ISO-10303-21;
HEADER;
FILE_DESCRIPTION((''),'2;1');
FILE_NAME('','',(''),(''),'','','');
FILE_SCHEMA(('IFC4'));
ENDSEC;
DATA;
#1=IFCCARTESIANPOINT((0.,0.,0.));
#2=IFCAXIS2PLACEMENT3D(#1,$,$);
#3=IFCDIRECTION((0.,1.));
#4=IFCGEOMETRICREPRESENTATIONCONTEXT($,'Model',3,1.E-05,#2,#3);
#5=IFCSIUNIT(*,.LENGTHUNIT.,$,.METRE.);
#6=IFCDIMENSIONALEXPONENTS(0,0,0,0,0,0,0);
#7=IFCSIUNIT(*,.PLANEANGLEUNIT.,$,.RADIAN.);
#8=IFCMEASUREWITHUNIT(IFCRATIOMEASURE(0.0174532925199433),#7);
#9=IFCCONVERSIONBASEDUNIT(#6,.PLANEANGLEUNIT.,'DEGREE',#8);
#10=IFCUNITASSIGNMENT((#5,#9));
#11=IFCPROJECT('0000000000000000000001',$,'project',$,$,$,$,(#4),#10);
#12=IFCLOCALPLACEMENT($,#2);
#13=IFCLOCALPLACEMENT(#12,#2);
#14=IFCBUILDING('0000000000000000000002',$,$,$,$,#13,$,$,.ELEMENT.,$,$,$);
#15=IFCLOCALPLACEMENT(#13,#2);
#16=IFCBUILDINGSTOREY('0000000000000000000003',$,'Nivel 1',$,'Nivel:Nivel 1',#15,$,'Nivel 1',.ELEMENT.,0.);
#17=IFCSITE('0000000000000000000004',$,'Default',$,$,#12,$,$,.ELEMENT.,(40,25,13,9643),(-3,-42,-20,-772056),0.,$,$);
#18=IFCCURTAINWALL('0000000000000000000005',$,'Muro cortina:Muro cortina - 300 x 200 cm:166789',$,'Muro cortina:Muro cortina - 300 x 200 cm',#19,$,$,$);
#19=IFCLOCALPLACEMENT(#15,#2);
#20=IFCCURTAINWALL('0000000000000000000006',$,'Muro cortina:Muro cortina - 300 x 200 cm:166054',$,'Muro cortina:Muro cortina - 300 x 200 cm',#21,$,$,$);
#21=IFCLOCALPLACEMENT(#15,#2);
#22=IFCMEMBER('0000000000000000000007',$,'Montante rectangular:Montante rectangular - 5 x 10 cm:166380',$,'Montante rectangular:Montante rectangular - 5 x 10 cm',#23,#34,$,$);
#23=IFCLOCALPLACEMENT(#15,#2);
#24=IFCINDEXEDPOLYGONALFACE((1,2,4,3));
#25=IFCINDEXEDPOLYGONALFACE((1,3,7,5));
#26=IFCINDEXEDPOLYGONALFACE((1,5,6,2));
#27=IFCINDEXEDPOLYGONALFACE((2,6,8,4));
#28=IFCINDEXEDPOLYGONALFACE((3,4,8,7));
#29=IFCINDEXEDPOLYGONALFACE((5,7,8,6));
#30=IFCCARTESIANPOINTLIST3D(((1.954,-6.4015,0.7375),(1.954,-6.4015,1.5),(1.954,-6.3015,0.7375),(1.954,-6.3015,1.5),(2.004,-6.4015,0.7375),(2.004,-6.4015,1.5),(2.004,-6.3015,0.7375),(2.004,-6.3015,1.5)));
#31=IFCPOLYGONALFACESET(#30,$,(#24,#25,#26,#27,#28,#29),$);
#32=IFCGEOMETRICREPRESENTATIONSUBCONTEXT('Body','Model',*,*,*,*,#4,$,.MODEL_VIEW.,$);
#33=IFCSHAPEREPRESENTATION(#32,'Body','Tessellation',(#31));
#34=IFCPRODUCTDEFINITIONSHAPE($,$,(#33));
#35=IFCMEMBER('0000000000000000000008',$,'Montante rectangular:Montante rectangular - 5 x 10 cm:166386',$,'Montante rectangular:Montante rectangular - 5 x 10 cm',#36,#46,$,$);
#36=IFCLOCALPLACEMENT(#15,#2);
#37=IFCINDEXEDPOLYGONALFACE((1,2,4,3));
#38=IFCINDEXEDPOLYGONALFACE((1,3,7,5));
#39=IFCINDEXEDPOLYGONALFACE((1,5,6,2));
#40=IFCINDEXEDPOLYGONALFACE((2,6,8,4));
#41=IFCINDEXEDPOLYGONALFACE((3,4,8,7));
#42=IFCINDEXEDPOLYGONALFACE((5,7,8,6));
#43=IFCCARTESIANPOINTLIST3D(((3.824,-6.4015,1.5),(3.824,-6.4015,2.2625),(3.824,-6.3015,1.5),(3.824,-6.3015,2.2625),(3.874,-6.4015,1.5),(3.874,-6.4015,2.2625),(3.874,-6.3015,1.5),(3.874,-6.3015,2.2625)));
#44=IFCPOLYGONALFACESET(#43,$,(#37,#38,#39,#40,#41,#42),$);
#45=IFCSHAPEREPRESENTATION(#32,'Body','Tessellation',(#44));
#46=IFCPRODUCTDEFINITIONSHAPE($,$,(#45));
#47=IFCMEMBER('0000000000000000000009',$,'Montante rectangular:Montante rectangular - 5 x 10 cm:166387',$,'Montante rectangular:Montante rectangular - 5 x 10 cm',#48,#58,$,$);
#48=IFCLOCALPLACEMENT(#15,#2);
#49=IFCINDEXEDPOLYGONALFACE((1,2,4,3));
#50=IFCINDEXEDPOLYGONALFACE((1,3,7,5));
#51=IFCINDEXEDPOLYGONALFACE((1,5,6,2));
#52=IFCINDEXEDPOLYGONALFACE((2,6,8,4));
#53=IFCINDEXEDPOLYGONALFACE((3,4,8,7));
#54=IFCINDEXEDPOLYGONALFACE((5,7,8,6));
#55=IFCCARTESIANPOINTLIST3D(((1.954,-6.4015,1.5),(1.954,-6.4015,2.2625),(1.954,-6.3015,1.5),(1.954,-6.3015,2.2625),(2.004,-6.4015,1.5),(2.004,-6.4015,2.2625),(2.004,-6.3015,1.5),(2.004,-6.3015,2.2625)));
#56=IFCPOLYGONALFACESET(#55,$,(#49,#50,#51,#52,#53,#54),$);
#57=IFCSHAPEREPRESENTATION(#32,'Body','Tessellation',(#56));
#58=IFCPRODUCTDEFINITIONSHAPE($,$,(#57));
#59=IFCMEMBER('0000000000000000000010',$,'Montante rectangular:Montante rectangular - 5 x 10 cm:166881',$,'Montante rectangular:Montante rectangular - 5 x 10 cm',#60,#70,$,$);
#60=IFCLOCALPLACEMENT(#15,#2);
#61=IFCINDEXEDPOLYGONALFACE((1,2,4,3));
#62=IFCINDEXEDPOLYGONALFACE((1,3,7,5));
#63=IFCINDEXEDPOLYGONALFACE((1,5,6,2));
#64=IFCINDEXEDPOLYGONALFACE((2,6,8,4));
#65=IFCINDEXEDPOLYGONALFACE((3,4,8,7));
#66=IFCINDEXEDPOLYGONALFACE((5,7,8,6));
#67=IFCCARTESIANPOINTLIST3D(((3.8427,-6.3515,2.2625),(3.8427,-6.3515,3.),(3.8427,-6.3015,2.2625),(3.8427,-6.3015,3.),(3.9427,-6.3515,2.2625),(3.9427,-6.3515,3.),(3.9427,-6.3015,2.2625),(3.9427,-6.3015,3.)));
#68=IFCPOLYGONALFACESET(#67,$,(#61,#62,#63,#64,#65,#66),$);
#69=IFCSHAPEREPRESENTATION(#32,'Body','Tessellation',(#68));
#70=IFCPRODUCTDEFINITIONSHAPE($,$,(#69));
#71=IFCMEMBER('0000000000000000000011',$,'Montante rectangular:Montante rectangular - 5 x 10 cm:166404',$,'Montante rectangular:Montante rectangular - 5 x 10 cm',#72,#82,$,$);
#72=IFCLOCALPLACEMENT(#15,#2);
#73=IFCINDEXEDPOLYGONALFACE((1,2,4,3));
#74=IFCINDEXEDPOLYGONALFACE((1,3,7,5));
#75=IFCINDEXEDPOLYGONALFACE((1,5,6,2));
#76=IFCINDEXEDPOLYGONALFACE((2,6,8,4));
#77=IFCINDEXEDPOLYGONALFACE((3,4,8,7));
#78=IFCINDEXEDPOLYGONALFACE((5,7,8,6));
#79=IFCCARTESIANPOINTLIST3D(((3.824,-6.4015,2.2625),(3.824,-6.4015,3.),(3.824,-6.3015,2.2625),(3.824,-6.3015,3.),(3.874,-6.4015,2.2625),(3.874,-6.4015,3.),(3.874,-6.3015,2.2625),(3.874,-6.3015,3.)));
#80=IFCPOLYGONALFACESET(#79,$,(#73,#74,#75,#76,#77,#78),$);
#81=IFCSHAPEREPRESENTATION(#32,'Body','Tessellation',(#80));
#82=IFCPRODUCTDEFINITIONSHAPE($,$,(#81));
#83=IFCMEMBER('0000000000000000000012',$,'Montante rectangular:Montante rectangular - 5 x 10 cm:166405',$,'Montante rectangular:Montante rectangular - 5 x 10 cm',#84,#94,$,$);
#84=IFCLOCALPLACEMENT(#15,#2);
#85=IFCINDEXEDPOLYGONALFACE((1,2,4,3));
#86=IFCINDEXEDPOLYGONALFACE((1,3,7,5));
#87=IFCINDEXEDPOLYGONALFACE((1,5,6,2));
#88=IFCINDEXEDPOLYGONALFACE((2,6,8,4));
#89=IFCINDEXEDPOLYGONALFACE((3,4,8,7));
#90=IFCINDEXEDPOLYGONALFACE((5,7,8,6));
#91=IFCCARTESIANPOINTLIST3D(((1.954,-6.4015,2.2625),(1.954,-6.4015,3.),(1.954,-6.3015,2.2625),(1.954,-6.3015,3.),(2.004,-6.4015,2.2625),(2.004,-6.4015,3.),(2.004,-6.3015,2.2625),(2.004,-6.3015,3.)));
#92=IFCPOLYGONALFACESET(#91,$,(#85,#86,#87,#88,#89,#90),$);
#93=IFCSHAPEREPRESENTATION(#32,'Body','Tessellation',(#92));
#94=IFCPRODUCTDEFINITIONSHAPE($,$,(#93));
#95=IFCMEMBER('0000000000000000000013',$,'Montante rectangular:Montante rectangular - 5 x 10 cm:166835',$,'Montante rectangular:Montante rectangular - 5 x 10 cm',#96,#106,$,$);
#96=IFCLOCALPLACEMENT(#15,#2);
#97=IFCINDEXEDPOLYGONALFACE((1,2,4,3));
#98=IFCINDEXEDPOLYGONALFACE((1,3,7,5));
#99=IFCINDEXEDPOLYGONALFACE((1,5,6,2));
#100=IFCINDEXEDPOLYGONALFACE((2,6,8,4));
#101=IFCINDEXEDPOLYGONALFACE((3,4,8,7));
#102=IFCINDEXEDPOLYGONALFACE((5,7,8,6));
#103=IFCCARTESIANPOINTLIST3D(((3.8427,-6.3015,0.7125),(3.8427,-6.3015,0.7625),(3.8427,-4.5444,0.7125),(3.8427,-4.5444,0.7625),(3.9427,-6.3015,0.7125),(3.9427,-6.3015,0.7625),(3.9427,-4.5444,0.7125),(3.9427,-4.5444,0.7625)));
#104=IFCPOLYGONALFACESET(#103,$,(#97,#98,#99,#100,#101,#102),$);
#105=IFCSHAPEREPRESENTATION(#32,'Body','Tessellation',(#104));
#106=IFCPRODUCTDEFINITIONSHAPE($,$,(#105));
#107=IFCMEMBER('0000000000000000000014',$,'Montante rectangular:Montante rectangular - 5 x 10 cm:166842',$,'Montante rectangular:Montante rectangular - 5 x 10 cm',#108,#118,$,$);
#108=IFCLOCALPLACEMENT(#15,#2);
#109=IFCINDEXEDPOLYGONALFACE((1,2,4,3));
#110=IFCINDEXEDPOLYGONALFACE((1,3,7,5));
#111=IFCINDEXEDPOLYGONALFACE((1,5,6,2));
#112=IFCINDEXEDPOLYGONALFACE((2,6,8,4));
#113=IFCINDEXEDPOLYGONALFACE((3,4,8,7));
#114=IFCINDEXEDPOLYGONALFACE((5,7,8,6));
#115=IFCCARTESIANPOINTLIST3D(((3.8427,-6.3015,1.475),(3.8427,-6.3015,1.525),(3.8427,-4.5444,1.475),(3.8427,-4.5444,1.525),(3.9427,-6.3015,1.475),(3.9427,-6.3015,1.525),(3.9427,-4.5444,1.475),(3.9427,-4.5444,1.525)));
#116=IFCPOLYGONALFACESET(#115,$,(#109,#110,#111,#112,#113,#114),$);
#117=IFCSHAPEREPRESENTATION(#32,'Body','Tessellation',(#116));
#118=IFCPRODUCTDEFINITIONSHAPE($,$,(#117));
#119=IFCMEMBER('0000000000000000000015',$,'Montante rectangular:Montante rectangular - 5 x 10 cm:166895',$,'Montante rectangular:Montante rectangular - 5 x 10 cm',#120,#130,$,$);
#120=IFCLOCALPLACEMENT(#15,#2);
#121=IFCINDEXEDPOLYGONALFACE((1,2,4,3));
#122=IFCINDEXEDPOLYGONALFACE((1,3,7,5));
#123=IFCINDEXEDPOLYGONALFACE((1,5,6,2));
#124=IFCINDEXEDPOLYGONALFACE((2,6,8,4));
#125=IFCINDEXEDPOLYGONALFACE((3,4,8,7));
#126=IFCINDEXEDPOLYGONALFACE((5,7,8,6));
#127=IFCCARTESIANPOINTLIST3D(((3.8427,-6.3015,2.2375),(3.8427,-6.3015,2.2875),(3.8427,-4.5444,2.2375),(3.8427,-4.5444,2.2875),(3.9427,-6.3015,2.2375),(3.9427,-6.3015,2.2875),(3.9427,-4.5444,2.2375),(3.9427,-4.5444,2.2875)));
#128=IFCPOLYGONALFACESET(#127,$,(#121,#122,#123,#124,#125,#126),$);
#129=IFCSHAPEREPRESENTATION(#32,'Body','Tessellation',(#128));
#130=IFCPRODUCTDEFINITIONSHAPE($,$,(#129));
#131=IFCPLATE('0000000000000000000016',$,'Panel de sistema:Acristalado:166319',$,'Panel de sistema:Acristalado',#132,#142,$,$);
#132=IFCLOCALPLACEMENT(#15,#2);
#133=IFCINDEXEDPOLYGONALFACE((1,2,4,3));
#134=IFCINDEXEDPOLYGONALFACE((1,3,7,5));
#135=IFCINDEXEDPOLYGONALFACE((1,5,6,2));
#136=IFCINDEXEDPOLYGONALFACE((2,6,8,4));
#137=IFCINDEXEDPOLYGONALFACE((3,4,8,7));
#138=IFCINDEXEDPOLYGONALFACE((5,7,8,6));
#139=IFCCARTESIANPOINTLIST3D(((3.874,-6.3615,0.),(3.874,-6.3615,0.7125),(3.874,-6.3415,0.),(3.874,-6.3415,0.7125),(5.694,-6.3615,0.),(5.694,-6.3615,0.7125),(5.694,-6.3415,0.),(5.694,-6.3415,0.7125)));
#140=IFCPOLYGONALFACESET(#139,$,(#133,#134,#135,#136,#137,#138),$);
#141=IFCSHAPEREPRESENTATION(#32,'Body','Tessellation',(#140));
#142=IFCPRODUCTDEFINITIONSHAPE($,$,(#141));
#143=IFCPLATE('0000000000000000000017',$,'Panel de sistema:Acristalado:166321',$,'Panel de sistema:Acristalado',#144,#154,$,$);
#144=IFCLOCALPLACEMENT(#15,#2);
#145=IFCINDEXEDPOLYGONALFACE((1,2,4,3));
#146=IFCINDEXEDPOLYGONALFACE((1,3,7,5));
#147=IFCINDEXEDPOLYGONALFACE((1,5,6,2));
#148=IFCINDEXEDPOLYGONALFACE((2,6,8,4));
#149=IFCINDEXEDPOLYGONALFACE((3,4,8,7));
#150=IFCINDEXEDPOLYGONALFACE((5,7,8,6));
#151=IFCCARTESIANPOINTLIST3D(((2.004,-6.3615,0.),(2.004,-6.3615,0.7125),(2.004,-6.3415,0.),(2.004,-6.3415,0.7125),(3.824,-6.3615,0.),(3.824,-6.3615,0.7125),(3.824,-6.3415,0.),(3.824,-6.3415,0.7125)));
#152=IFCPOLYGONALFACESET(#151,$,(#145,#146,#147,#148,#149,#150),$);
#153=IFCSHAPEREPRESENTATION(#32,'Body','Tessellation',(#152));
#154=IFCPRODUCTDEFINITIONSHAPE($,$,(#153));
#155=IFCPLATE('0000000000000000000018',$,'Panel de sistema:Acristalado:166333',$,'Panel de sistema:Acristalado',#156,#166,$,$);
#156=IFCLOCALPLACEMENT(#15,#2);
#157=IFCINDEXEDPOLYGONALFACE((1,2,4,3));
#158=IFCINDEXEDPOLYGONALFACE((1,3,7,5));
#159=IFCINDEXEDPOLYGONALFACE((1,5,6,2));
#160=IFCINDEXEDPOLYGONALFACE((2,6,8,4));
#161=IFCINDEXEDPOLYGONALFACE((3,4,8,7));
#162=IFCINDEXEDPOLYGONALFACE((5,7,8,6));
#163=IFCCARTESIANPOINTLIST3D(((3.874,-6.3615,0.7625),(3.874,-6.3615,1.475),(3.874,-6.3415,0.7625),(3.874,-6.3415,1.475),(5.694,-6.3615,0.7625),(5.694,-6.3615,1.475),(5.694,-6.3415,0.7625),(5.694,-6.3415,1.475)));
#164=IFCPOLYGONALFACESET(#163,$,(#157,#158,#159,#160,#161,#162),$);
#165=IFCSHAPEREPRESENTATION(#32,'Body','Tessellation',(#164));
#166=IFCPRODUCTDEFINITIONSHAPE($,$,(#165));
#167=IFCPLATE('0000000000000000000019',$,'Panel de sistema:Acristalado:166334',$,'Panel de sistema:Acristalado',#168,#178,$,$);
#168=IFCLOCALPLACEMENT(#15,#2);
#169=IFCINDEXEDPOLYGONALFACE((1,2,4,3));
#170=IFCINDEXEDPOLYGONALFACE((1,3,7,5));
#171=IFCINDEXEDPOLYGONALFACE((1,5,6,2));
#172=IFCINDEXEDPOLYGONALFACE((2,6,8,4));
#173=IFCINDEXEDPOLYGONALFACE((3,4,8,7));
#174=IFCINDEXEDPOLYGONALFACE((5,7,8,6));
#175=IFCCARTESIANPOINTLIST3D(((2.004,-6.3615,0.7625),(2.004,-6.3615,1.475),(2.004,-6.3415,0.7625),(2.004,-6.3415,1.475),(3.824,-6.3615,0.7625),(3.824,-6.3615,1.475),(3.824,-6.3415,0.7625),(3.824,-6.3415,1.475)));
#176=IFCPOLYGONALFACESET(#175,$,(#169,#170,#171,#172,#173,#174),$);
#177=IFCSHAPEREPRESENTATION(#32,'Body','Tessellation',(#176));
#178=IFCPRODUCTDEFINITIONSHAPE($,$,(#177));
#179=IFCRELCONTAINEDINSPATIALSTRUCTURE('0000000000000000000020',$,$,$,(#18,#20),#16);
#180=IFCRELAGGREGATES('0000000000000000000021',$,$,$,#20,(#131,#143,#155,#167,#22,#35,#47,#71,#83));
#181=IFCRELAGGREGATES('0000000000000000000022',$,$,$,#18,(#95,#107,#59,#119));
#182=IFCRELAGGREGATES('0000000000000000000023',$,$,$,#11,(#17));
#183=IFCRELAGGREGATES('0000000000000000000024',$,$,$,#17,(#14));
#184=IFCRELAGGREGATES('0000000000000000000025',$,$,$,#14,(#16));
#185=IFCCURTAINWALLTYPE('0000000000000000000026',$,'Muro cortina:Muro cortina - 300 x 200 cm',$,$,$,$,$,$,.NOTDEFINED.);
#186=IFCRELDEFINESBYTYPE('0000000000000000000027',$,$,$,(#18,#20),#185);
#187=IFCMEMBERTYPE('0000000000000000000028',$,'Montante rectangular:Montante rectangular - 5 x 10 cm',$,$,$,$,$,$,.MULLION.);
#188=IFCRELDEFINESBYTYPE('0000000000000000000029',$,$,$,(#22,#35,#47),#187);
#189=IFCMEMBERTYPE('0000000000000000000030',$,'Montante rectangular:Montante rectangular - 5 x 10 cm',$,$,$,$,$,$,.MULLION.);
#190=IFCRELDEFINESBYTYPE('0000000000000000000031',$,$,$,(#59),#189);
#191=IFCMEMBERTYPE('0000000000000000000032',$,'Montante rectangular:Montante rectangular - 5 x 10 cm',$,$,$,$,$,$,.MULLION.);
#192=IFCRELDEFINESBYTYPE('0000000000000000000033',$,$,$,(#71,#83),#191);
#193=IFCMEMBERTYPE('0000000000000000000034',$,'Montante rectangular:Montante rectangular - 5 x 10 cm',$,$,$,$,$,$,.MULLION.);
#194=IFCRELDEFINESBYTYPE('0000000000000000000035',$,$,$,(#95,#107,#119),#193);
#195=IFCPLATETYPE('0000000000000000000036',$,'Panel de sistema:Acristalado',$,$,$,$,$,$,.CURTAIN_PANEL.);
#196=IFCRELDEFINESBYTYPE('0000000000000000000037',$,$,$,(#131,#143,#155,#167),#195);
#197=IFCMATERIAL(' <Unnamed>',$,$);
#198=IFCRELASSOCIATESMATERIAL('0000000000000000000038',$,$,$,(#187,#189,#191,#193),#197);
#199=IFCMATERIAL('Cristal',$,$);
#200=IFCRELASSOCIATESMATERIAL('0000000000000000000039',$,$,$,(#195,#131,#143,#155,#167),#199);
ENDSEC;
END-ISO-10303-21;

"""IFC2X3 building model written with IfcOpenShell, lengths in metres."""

from ifc_helpers import new_model, entity, si_unit, converted_unit, direction, frame, origin, origin_2d_with_axis, place, context, subcontext, project, spatial, rectangle, extrude, source, transform, mapped, material, type_object, type_shapes, element, aggregate, save


model = new_model("IFC2X3")

# Units and contexts
model_context = context("Model", 3, precision=1e-05, world=origin(), true_north=direction((0.0, 1.0)))
body_context = subcontext(model_context, "Body", "Model", "MODEL_VIEW")
ifc_project = project(units=[si_unit("LENGTHUNIT", "METRE"), converted_unit("PLANEANGLEUNIT", "DEGREE", entity("IfcRatioMeasure", 0.0174532925199433), si_unit("PLANEANGLEUNIT", "RADIAN"), dimensions=[0, 0, 0, 0, 0, 0, 0])], contexts=[model_context])

# Site, building, storey
site_placement = place(None, origin())
site = spatial("IfcSite", under=ifc_project, at=site_placement, Name="Default", CompositionType="ELEMENT", RefLatitude=(40, 25, 13, 9643), RefLongitude=(-3, -42, -20, -772056), RefElevation=0.0)
building_placement = place(site_placement, origin())
building = spatial("IfcBuilding", under=site, at=building_placement, CompositionType="ELEMENT")
storey_placement = place(building_placement, origin())
storey = spatial("IfcBuildingStorey", under=building, at=storey_placement, Name="Nivel 1", ObjectType="Nivel:Nivel 1", LongName="Nivel 1", CompositionType="ELEMENT", Elevation=0.0)

# Curtain walls, members
curtain_wall_type = type_object("IfcCurtainWallType", Name="Muro cortina:Muro cortina - 300 x 200 cm", PredefinedType="NOTDEFINED")
curtain_wall_1_placement = place(storey_placement, origin())
curtain_wall_1 = element("IfcCurtainWall", 1, at=curtain_wall_1_placement, inside=storey, type_object=curtain_wall_type, Name="Muro cortina:Muro cortina - 300 x 200 cm:166789", ObjectType="Muro cortina:Muro cortina - 300 x 200 cm")
ifc_material_1 = material(Name=" <Unnamed>")
curtain_wall_2_placement = place(storey_placement, origin())
curtain_wall_2 = element("IfcCurtainWall", 2, at=curtain_wall_2_placement, inside=storey, type_object=curtain_wall_type, Name="Muro cortina:Muro cortina - 300 x 200 cm:166054", ObjectType="Muro cortina:Muro cortina - 300 x 200 cm")
member_type_1 = type_object("IfcMemberType", Name="Montante rectangular:Montante rectangular - 5 x 10 cm", PredefinedType="MULLION", material=ifc_material_1)
shared_shape_1 = source(origin(), body_context, "Body", "SweptSolid", [
    extrude(rectangle(XDim=0.1, YDim=0.05, at=origin_2d_with_axis()), frame((0.0, 0.0, -0.7625), z_axis=(0.0, 0.0, 1.0), x_axis=(0.0, -1.0, 0.0)), (0.0, 0.0, 1.0), 0.7625),
])
type_shapes(member_type_1, [shared_shape_1])
member_1_placement = place(storey_placement, frame((1.979, -6.3515, 0.7375), z_axis=(0.0, 0.0, -1.0), x_axis=(-1.0, 0.0, 0.0)))
member_1 = element("IfcMember", 3, at=member_1_placement, type_object=member_type_1, Name="Montante rectangular:Montante rectangular - 5 x 10 cm:166380", ObjectType="Montante rectangular:Montante rectangular - 5 x 10 cm", context=body_context, shape_type="MappedRepresentation", body=[
    mapped(shared_shape_1, transform((0.0, 0.0, 0.0), scale=1.0)),
])
member_2_placement = place(storey_placement, frame((3.849, -6.3515, 1.5), z_axis=(0.0, 0.0, -1.0), x_axis=(-1.0, 0.0, 0.0)))
member_2 = element("IfcMember", 4, at=member_2_placement, type_object=member_type_1, Name="Montante rectangular:Montante rectangular - 5 x 10 cm:166386", ObjectType="Montante rectangular:Montante rectangular - 5 x 10 cm", context=body_context, shape_type="MappedRepresentation", body=[
    mapped(shared_shape_1, transform((0.0, 0.0, 0.0), scale=1.0)),
])
member_3_placement = place(storey_placement, frame((1.979, -6.3515, 1.5), z_axis=(0.0, 0.0, -1.0), x_axis=(-1.0, 0.0, 0.0)))
member_3 = element("IfcMember", 5, at=member_3_placement, type_object=member_type_1, Name="Montante rectangular:Montante rectangular - 5 x 10 cm:166387", ObjectType="Montante rectangular:Montante rectangular - 5 x 10 cm", context=body_context, shape_type="MappedRepresentation", body=[
    mapped(shared_shape_1, transform((0.0, 0.0, 0.0), scale=1.0)),
])

# Members
member_type_2 = type_object("IfcMemberType", Name="Montante rectangular:Montante rectangular - 5 x 10 cm", PredefinedType="MULLION", material=ifc_material_1)
shared_shape_2 = source(origin(), body_context, "Body", "SweptSolid", [
    extrude(rectangle(XDim=0.1, YDim=0.05, at=origin_2d_with_axis()), frame((-0.025, 0.0, -0.7375), z_axis=(0.0, 0.0, 1.0), x_axis=(0.0, -1.0, 0.0)), (0.0, 0.0, 1.0), 0.7375),
])
type_shapes(member_type_2, [shared_shape_2])
member_4_placement = place(storey_placement, frame((3.8927, -6.3515, 2.2625), z_axis=(0.0, 0.0, -1.0), x_axis=(0.0, -1.0, 0.0)))
member_4 = element("IfcMember", 6, at=member_4_placement, type_object=member_type_2, Name="Montante rectangular:Montante rectangular - 5 x 10 cm:166881", ObjectType="Montante rectangular:Montante rectangular - 5 x 10 cm", context=body_context, shape_type="MappedRepresentation", body=[
    mapped(shared_shape_2, transform((0.0, 0.0, 0.0), scale=1.0)),
])
member_type_3 = type_object("IfcMemberType", Name="Montante rectangular:Montante rectangular - 5 x 10 cm", PredefinedType="MULLION", material=ifc_material_1)
shared_shape_3 = source(origin(), body_context, "Body", "SweptSolid", [
    extrude(rectangle(XDim=0.1, YDim=0.05, at=origin_2d_with_axis()), frame((0.0, 0.0, -0.7375), z_axis=(0.0, 0.0, 1.0), x_axis=(0.0, -1.0, 0.0)), (0.0, 0.0, 1.0), 0.7375),
])
type_shapes(member_type_3, [shared_shape_3])
member_5_placement = place(storey_placement, frame((3.849, -6.3515, 2.2625), z_axis=(0.0, 0.0, -1.0), x_axis=(-1.0, 0.0, 0.0)))
member_5 = element("IfcMember", 7, at=member_5_placement, type_object=member_type_3, Name="Montante rectangular:Montante rectangular - 5 x 10 cm:166404", ObjectType="Montante rectangular:Montante rectangular - 5 x 10 cm", context=body_context, shape_type="MappedRepresentation", body=[
    mapped(shared_shape_3, transform((0.0, 0.0, 0.0), scale=1.0)),
])
member_6_placement = place(storey_placement, frame((1.979, -6.3515, 2.2625), z_axis=(0.0, 0.0, -1.0), x_axis=(-1.0, 0.0, 0.0)))
member_6 = element("IfcMember", 8, at=member_6_placement, type_object=member_type_3, Name="Montante rectangular:Montante rectangular - 5 x 10 cm:166405", ObjectType="Montante rectangular:Montante rectangular - 5 x 10 cm", context=body_context, shape_type="MappedRepresentation", body=[
    mapped(shared_shape_3, transform((0.0, 0.0, 0.0), scale=1.0)),
])
member_type_4 = type_object("IfcMemberType", Name="Montante rectangular:Montante rectangular - 5 x 10 cm", PredefinedType="MULLION", material=ifc_material_1)
shared_shape_4 = source(origin(), body_context, "Body", "SweptSolid", [
    extrude(rectangle(XDim=0.1, YDim=0.05, at=origin_2d_with_axis()), frame((0.0, 0.0, -1.7571), z_axis=(0.0, 0.0, 1.0), x_axis=(0.0, -1.0, 0.0)), (0.0, 0.0, 1.0), 1.7571),
])
type_shapes(member_type_4, [shared_shape_4])
member_7_placement = place(storey_placement, frame((3.8927, -6.3015, 0.7375), z_axis=(0.0, -1.0, 0.0), x_axis=(0.0, 0.0, 1.0)))
member_7 = element("IfcMember", 9, at=member_7_placement, type_object=member_type_4, Name="Montante rectangular:Montante rectangular - 5 x 10 cm:166835", ObjectType="Montante rectangular:Montante rectangular - 5 x 10 cm", context=body_context, shape_type="MappedRepresentation", body=[
    mapped(shared_shape_4, transform((0.0, 0.0, 0.0), scale=1.0)),
])
member_8_placement = place(storey_placement, frame((3.8927, -6.3015, 1.5), z_axis=(0.0, -1.0, 0.0), x_axis=(0.0, 0.0, 1.0)))
member_8 = element("IfcMember", 10, at=member_8_placement, type_object=member_type_4, Name="Montante rectangular:Montante rectangular - 5 x 10 cm:166842", ObjectType="Montante rectangular:Montante rectangular - 5 x 10 cm", context=body_context, shape_type="MappedRepresentation", body=[
    mapped(shared_shape_4, transform((0.0, 0.0, 0.0), scale=1.0)),
])
member_9_placement = place(storey_placement, frame((3.8927, -6.3015, 2.2625), z_axis=(0.0, -1.0, 0.0), x_axis=(0.0, 0.0, 1.0)))
member_9 = element("IfcMember", 11, at=member_9_placement, type_object=member_type_4, Name="Montante rectangular:Montante rectangular - 5 x 10 cm:166895", ObjectType="Montante rectangular:Montante rectangular - 5 x 10 cm", context=body_context, shape_type="MappedRepresentation", body=[
    mapped(shared_shape_4, transform((0.0, 0.0, 0.0), scale=1.0)),
])

# Plates
ifc_material_2 = material(Name="Cristal")
plate_type_1 = type_object("IfcPlateType", Name="Panel de sistema:Acristalado", PredefinedType="CURTAIN_PANEL", material=ifc_material_2)
shared_shape_5 = source(origin(), body_context, "Body", "SweptSolid", [
    extrude(rectangle(XDim=0.02, YDim=1.82, at=origin_2d_with_axis()), frame((0.0, 0.0, 0.0), z_axis=(0.0, 0.0, 1.0), x_axis=(0.0, 1.0, 0.0)), (0.0, 0.0, 1.0), 0.7125),
])
type_shapes(plate_type_1, [shared_shape_5])
plate_1_placement = place(curtain_wall_2_placement, frame((4.784, -6.3515, 0.0), z_axis=(0.0, 0.0, 1.0), x_axis=(-1.0, 0.0, 0.0)))
plate_1 = element("IfcPlate", 12, at=plate_1_placement, type_object=plate_type_1, material=ifc_material_2, Name="Panel de sistema:Acristalado:166319", ObjectType="Panel de sistema:Acristalado", context=body_context, shape_type="MappedRepresentation", body=[
    mapped(shared_shape_5, transform((0.0, 0.0, 0.0), scale=1.0)),
])
plate_2_placement = place(curtain_wall_2_placement, frame((2.914, -6.3515, 0.0), z_axis=(0.0, 0.0, 1.0), x_axis=(-1.0, 0.0, 0.0)))
plate_2 = element("IfcPlate", 13, at=plate_2_placement, type_object=plate_type_1, material=ifc_material_2, Name="Panel de sistema:Acristalado:166321", ObjectType="Panel de sistema:Acristalado", context=body_context, shape_type="MappedRepresentation", body=[
    mapped(shared_shape_5, transform((0.0, 0.0, 0.0), scale=1.0)),
])
plate_3_placement = place(curtain_wall_2_placement, frame((4.784, -6.3515, 0.7625), z_axis=(0.0, 0.0, 1.0), x_axis=(-1.0, 0.0, 0.0)))
plate_3 = element("IfcPlate", 14, at=plate_3_placement, type_object=plate_type_1, material=ifc_material_2, Name="Panel de sistema:Acristalado:166333", ObjectType="Panel de sistema:Acristalado", context=body_context, shape_type="MappedRepresentation", body=[
    mapped(shared_shape_5, transform((0.0, 0.0, 0.0), scale=1.0)),
])
plate_4_placement = place(curtain_wall_2_placement, frame((2.914, -6.3515, 0.7625), z_axis=(0.0, 0.0, 1.0), x_axis=(-1.0, 0.0, 0.0)))
plate_4 = element("IfcPlate", 15, at=plate_4_placement, type_object=plate_type_1, material=ifc_material_2, Name="Panel de sistema:Acristalado:166334", ObjectType="Panel de sistema:Acristalado", context=body_context, shape_type="MappedRepresentation", body=[
    mapped(shared_shape_5, transform((0.0, 0.0, 0.0), scale=1.0)),
])
aggregate(curtain_wall_2, [plate_1, plate_2, plate_3, plate_4, member_1, member_2, member_3, member_5, member_6])
aggregate(curtain_wall_1, [member_7, member_8, member_4, member_9])

save(model, "model.ifc")
